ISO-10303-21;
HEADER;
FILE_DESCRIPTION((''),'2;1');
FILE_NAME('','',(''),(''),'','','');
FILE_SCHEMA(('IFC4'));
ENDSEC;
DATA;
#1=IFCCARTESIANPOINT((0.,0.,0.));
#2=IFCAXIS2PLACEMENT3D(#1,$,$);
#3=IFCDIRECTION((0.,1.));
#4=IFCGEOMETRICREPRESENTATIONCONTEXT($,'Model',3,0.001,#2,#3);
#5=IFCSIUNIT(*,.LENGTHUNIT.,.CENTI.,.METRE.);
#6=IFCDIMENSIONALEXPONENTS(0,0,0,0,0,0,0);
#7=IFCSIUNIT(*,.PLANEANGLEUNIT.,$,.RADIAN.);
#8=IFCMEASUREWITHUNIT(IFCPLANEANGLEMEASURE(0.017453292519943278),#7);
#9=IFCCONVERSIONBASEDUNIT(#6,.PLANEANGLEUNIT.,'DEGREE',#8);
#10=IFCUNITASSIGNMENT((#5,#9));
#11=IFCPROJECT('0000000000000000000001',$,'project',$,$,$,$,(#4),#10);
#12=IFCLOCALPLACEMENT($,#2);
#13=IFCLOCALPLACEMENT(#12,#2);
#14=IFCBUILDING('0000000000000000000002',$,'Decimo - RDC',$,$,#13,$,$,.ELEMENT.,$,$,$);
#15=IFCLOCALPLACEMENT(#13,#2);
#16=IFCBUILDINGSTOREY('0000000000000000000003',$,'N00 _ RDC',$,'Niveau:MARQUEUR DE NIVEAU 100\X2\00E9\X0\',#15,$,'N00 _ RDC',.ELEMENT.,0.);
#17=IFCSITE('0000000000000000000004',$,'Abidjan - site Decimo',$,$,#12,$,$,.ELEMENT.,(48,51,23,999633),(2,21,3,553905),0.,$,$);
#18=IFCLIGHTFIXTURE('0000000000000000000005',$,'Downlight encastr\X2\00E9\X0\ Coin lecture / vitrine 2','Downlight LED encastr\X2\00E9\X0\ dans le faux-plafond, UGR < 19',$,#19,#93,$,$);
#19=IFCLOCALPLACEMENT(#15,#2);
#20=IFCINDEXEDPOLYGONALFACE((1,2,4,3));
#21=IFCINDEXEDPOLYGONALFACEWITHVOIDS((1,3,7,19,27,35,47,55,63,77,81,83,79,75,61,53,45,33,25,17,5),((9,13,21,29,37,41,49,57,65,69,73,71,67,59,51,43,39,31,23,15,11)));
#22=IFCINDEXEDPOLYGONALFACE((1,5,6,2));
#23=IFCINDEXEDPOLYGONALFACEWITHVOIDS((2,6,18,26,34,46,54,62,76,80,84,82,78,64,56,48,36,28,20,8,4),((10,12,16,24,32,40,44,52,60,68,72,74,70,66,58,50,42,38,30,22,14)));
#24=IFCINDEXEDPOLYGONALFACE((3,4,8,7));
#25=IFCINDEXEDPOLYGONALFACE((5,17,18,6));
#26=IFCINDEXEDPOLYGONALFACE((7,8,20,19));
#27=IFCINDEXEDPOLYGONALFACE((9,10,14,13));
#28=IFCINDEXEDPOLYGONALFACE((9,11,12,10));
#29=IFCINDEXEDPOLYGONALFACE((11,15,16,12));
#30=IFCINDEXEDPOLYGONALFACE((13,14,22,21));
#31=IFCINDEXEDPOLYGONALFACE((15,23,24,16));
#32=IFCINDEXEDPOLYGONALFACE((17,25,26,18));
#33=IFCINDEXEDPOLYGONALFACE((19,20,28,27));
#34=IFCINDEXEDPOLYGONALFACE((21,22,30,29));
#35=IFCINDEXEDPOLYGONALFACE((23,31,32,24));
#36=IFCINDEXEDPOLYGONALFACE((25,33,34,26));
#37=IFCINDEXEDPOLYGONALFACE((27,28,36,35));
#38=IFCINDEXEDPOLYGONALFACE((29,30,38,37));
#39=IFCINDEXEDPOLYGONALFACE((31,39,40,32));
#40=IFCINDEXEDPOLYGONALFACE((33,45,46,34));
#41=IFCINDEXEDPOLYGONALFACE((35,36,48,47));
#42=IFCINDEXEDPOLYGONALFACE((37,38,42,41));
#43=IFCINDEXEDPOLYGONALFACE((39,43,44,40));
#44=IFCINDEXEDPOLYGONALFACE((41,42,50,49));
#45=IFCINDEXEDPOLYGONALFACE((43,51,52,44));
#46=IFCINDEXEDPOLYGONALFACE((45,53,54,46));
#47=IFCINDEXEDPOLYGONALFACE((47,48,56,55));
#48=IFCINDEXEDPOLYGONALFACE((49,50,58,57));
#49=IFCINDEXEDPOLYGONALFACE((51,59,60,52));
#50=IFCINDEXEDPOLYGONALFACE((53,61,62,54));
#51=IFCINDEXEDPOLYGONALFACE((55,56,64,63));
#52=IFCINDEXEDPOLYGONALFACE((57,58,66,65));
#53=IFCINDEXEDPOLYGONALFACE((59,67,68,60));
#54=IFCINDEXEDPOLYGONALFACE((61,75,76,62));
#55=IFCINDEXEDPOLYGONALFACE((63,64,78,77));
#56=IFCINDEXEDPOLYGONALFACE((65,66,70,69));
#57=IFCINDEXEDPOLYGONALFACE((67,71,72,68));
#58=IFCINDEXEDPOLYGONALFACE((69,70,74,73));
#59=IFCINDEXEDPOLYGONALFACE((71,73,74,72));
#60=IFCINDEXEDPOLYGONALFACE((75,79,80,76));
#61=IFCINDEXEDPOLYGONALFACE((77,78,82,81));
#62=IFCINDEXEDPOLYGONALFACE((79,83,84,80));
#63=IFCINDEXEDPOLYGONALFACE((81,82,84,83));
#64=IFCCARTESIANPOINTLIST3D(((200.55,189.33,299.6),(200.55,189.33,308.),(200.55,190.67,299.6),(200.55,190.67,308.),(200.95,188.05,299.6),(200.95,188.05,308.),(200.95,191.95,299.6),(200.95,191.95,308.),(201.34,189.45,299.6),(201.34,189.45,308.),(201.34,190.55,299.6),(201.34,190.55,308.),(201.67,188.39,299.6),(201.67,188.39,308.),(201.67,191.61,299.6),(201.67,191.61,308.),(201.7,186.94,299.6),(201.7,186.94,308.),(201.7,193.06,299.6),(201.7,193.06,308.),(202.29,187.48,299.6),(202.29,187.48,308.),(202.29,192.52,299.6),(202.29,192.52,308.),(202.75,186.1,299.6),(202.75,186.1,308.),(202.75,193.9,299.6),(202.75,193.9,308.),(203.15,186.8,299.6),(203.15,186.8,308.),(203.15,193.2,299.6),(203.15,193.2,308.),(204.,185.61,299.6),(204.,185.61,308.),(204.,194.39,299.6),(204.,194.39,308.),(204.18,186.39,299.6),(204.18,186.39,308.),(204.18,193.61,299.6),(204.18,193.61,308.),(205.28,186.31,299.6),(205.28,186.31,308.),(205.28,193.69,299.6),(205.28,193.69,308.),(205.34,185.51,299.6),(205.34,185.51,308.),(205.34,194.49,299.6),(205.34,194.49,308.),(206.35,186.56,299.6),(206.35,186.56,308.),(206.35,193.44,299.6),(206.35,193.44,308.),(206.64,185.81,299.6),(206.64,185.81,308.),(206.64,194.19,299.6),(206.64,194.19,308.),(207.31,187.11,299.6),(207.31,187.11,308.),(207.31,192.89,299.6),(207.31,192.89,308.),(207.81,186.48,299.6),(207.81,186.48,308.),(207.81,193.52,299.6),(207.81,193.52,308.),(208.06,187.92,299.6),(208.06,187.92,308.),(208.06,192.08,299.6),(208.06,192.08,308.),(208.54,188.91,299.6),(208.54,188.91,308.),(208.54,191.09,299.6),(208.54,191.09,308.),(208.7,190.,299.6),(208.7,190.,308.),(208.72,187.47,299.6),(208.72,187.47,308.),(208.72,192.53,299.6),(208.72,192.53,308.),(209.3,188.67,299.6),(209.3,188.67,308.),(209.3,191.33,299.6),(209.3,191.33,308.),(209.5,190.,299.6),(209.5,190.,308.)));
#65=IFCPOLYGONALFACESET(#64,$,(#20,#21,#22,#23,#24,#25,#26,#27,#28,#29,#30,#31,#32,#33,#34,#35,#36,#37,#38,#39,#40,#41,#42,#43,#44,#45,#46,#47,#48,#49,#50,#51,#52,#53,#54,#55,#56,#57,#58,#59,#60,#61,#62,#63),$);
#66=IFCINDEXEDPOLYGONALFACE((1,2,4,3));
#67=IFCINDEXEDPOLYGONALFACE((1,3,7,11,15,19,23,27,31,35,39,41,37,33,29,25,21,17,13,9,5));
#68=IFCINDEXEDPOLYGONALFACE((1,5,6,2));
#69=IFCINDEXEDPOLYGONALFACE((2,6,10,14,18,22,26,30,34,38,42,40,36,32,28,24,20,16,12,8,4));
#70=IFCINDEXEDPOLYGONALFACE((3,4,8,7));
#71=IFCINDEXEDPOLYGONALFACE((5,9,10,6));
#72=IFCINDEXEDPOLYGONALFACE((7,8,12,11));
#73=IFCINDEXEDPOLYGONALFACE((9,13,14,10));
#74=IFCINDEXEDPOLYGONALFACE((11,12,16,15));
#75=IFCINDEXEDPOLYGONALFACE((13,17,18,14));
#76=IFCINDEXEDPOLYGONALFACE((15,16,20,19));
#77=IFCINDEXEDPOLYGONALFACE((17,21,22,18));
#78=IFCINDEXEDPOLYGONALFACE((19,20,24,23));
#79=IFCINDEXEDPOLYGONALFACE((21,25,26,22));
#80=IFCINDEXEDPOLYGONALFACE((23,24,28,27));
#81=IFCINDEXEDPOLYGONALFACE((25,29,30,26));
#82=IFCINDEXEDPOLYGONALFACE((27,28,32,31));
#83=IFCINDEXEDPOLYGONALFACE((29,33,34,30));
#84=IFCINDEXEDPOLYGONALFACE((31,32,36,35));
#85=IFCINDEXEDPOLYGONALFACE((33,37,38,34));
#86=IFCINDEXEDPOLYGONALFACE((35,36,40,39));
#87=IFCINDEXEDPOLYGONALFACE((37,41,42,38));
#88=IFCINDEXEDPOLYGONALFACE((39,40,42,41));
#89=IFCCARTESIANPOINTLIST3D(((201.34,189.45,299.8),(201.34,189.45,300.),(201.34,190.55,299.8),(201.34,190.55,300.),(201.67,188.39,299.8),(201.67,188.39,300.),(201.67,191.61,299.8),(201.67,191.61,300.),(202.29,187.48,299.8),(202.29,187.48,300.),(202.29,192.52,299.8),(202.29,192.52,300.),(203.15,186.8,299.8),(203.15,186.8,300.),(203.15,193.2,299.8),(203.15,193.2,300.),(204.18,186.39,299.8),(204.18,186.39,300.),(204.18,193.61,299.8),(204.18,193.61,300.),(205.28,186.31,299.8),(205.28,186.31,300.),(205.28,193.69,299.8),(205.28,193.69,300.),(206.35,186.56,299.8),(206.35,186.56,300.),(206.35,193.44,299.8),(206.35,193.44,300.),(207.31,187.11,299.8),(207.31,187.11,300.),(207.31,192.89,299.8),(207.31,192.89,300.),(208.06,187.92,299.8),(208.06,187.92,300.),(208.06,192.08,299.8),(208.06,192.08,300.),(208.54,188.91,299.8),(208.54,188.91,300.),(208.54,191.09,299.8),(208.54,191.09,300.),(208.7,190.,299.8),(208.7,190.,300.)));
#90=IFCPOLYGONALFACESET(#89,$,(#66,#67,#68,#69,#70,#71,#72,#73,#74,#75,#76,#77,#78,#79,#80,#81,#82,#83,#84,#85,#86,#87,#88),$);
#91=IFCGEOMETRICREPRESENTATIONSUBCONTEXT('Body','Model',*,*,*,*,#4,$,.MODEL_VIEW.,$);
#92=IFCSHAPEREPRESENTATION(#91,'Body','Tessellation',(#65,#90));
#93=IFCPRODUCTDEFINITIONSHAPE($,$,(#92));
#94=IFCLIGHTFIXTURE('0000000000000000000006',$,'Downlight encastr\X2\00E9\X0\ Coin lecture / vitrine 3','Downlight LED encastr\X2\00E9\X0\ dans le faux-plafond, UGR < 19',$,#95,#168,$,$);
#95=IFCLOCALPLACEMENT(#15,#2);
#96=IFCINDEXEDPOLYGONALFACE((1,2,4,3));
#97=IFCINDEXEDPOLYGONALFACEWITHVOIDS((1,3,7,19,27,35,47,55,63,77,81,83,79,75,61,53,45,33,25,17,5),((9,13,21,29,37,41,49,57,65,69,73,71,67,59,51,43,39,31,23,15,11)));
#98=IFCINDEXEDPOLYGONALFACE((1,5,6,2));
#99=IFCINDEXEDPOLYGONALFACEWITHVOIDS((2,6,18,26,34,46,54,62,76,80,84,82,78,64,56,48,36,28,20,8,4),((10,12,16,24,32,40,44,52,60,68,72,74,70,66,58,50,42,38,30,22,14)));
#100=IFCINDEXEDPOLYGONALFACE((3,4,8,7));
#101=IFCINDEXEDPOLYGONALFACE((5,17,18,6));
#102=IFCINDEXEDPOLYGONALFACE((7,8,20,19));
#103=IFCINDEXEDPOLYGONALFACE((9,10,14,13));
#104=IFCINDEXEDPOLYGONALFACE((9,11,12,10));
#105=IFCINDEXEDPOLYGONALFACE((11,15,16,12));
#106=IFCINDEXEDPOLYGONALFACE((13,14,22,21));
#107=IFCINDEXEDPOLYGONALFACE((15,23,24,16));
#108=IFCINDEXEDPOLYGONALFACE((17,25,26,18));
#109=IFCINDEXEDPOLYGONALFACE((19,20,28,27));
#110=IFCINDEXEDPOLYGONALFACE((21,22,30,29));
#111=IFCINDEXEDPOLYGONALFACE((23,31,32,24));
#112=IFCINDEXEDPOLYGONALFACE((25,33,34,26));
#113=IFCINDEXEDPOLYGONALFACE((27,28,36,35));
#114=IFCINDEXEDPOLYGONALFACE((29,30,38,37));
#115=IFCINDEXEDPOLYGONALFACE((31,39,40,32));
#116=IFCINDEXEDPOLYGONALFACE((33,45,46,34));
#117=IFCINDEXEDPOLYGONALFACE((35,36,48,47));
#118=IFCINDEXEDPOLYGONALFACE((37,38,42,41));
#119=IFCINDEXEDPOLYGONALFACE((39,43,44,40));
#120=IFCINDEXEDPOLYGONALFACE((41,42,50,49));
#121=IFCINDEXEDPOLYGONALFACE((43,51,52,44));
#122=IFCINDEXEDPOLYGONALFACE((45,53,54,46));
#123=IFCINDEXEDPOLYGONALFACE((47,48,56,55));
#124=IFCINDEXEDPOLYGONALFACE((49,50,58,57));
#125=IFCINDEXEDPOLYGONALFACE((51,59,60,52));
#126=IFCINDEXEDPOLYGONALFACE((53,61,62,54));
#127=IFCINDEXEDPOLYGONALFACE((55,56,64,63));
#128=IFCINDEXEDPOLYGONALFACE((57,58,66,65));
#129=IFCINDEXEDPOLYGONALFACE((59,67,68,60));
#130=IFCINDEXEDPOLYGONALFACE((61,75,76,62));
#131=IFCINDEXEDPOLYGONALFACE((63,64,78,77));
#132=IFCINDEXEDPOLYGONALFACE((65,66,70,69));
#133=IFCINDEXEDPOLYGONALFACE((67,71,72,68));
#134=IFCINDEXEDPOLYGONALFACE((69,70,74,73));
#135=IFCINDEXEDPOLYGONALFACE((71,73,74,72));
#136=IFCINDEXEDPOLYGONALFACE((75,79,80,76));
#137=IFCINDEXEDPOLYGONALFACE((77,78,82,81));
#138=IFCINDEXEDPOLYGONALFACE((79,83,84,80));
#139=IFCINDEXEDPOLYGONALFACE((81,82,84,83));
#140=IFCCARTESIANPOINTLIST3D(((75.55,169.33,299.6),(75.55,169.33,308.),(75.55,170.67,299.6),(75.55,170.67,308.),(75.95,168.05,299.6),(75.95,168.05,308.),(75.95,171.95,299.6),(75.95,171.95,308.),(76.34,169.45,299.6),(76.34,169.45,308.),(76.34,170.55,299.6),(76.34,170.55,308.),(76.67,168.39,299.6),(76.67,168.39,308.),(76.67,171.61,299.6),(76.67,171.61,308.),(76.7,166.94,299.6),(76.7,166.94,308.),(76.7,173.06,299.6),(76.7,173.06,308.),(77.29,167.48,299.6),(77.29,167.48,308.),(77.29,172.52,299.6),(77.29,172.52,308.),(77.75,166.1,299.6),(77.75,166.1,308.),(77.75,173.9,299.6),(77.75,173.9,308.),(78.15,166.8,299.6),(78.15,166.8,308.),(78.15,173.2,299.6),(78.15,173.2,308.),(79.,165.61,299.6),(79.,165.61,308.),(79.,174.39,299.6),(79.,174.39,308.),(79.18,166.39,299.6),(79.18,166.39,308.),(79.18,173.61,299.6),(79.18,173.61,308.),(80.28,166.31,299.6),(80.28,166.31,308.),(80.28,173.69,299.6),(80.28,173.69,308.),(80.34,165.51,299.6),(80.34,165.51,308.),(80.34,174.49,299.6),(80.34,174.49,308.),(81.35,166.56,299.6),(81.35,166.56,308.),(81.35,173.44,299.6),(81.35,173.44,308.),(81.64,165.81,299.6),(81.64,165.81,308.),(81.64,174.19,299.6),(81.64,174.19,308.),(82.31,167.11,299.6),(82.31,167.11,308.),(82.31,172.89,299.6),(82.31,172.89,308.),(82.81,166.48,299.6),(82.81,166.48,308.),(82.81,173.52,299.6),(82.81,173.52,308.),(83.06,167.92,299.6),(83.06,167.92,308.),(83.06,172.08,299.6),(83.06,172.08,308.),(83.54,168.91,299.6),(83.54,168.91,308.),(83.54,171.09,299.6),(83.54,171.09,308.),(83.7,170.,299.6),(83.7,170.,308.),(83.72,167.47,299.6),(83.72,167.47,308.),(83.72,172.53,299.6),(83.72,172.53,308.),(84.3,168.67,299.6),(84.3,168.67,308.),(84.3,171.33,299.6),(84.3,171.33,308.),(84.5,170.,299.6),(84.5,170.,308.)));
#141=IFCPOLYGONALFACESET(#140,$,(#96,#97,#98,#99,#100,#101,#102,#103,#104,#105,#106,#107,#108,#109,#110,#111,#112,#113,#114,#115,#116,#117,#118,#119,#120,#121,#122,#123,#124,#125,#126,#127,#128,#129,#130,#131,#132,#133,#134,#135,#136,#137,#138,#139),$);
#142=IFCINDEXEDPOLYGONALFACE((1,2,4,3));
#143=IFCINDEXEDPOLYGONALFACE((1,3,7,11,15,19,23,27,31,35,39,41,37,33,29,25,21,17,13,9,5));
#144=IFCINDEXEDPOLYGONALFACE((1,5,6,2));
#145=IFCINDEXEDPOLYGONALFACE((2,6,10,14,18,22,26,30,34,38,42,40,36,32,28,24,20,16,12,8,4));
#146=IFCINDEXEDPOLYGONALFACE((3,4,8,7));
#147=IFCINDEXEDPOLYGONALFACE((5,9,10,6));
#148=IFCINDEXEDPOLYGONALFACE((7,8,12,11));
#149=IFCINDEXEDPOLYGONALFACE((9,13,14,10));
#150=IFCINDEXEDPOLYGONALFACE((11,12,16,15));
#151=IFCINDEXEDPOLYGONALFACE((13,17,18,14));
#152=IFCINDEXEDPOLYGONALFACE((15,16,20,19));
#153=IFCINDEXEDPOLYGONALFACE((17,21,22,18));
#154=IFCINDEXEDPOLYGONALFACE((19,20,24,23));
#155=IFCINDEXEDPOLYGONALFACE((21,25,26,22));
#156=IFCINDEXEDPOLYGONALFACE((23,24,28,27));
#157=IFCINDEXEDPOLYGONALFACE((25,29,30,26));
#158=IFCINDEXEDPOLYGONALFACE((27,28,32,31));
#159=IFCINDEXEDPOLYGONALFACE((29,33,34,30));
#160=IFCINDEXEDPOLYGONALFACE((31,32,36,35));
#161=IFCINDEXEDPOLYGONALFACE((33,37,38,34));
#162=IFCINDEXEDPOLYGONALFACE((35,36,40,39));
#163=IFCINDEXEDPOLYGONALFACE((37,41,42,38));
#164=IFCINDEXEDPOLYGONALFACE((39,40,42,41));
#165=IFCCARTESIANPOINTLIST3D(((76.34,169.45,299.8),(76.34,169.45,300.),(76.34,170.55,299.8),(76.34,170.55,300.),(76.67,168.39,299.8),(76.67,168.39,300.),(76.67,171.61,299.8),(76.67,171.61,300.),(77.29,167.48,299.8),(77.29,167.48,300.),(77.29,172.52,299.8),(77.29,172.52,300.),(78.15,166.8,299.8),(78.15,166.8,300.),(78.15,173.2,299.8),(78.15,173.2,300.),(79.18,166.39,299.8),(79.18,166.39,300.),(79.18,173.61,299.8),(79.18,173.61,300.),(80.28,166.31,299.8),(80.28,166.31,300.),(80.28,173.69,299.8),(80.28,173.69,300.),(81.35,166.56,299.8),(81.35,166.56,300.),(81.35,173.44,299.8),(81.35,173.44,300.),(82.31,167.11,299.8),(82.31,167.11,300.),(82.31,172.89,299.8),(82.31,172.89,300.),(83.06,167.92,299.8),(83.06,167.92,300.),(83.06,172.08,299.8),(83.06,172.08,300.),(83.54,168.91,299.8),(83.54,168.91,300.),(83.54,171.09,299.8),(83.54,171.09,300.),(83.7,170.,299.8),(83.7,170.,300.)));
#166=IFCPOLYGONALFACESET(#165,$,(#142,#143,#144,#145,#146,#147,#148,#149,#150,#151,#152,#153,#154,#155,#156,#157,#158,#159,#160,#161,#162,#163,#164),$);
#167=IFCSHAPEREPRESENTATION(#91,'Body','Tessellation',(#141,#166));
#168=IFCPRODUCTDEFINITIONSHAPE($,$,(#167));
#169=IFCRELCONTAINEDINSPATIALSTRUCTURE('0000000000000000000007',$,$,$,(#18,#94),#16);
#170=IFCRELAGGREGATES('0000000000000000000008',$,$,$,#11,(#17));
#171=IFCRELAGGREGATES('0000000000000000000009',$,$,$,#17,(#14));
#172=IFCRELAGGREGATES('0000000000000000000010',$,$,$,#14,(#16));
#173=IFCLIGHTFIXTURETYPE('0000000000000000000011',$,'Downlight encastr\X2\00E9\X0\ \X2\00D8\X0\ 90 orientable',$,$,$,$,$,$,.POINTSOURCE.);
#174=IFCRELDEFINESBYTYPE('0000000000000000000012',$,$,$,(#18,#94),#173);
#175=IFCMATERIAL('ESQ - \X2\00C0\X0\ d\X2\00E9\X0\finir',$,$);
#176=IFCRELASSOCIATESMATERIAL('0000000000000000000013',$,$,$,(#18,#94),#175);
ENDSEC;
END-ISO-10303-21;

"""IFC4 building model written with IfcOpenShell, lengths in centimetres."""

from ifc_helpers import new_model, entity, si_unit, converted_unit, direction, frame, frame_2d, origin, origin_with_axes, place, context, subcontext, project, spatial, circle, hollow_circle, extrude, material, type_object, element, save


model = new_model("IFC4")

# Units and contexts
model_context = context("Model", 3, precision=0.001, world=origin(), true_north=direction((0.0, 1.0)))
body_context = subcontext(model_context, "Body", "Model", "MODEL_VIEW")
ifc_project = project(units=[si_unit("LENGTHUNIT", "METRE", prefix="CENTI"), converted_unit("PLANEANGLEUNIT", "DEGREE", entity("IfcPlaneAngleMeasure", 0.017453292519943278), si_unit("PLANEANGLEUNIT", "RADIAN"), dimensions=[0, 0, 0, 0, 0, 0, 0])], contexts=[model_context])

# Site, building, storey
site_placement = place(None, origin())
site = spatial("IfcSite", under=ifc_project, at=site_placement, Name="Abidjan - site Decimo", CompositionType="ELEMENT", RefLatitude=(48, 51, 23, 999633), RefLongitude=(2, 21, 3, 553905), RefElevation=0.0)
building_placement = place(site_placement, origin())
building = spatial("IfcBuilding", under=site, at=building_placement, Name="Decimo - RDC", CompositionType="ELEMENT")
storey_placement = place(building_placement, origin())
storey = spatial("IfcBuildingStorey", under=building, at=storey_placement, Name="N00 _ RDC", ObjectType="Niveau:MARQUEUR DE NIVEAU 100é", LongName="N00 _ RDC", CompositionType="ELEMENT", Elevation=0.0)

# Light fixtures
ifc_material_1 = material(Name="ESQ - À définir")
light_fixture_type_1 = type_object("IfcLightFixtureType", Name="Downlight encastré Ø 90 orientable", PredefinedType="POINTSOURCE")
light_fixture_1_placement = place(storey_placement, origin_with_axes())
element("IfcLightFixture", 1, at=light_fixture_1_placement, inside=storey, type_object=light_fixture_type_1, material=ifc_material_1, Name="Downlight encastré Coin lecture / vitrine 2", Description="Downlight LED encastré dans le faux-plafond, UGR < 19", context=body_context, shape_type="SweptSolid", body=[
    extrude(hollow_circle(Radius=4.5, WallThickness=0.8, at=frame_2d((205.0, 190.0))), frame((0.0, 0.0, 299.6)), (0.0, 0.0, 1.0), 8.4),
    extrude(circle(Radius=3.7, at=frame_2d((205.0, 190.0))), frame((0.0, 0.0, 299.8)), (0.0, 0.0, 1.0), 0.2),
])
light_fixture_2_placement = place(storey_placement, origin_with_axes())
element("IfcLightFixture", 2, at=light_fixture_2_placement, inside=storey, type_object=light_fixture_type_1, material=ifc_material_1, Name="Downlight encastré Coin lecture / vitrine 3", Description="Downlight LED encastré dans le faux-plafond, UGR < 19", context=body_context, shape_type="SweptSolid", body=[
    extrude(hollow_circle(Radius=4.5, WallThickness=0.8, at=frame_2d((80.0, 170.0))), frame((0.0, 0.0, 299.6)), (0.0, 0.0, 1.0), 8.4),
    extrude(circle(Radius=3.7, at=frame_2d((80.0, 170.0))), frame((0.0, 0.0, 299.8)), (0.0, 0.0, 1.0), 0.2),
])

save(model, "model.ifc")
